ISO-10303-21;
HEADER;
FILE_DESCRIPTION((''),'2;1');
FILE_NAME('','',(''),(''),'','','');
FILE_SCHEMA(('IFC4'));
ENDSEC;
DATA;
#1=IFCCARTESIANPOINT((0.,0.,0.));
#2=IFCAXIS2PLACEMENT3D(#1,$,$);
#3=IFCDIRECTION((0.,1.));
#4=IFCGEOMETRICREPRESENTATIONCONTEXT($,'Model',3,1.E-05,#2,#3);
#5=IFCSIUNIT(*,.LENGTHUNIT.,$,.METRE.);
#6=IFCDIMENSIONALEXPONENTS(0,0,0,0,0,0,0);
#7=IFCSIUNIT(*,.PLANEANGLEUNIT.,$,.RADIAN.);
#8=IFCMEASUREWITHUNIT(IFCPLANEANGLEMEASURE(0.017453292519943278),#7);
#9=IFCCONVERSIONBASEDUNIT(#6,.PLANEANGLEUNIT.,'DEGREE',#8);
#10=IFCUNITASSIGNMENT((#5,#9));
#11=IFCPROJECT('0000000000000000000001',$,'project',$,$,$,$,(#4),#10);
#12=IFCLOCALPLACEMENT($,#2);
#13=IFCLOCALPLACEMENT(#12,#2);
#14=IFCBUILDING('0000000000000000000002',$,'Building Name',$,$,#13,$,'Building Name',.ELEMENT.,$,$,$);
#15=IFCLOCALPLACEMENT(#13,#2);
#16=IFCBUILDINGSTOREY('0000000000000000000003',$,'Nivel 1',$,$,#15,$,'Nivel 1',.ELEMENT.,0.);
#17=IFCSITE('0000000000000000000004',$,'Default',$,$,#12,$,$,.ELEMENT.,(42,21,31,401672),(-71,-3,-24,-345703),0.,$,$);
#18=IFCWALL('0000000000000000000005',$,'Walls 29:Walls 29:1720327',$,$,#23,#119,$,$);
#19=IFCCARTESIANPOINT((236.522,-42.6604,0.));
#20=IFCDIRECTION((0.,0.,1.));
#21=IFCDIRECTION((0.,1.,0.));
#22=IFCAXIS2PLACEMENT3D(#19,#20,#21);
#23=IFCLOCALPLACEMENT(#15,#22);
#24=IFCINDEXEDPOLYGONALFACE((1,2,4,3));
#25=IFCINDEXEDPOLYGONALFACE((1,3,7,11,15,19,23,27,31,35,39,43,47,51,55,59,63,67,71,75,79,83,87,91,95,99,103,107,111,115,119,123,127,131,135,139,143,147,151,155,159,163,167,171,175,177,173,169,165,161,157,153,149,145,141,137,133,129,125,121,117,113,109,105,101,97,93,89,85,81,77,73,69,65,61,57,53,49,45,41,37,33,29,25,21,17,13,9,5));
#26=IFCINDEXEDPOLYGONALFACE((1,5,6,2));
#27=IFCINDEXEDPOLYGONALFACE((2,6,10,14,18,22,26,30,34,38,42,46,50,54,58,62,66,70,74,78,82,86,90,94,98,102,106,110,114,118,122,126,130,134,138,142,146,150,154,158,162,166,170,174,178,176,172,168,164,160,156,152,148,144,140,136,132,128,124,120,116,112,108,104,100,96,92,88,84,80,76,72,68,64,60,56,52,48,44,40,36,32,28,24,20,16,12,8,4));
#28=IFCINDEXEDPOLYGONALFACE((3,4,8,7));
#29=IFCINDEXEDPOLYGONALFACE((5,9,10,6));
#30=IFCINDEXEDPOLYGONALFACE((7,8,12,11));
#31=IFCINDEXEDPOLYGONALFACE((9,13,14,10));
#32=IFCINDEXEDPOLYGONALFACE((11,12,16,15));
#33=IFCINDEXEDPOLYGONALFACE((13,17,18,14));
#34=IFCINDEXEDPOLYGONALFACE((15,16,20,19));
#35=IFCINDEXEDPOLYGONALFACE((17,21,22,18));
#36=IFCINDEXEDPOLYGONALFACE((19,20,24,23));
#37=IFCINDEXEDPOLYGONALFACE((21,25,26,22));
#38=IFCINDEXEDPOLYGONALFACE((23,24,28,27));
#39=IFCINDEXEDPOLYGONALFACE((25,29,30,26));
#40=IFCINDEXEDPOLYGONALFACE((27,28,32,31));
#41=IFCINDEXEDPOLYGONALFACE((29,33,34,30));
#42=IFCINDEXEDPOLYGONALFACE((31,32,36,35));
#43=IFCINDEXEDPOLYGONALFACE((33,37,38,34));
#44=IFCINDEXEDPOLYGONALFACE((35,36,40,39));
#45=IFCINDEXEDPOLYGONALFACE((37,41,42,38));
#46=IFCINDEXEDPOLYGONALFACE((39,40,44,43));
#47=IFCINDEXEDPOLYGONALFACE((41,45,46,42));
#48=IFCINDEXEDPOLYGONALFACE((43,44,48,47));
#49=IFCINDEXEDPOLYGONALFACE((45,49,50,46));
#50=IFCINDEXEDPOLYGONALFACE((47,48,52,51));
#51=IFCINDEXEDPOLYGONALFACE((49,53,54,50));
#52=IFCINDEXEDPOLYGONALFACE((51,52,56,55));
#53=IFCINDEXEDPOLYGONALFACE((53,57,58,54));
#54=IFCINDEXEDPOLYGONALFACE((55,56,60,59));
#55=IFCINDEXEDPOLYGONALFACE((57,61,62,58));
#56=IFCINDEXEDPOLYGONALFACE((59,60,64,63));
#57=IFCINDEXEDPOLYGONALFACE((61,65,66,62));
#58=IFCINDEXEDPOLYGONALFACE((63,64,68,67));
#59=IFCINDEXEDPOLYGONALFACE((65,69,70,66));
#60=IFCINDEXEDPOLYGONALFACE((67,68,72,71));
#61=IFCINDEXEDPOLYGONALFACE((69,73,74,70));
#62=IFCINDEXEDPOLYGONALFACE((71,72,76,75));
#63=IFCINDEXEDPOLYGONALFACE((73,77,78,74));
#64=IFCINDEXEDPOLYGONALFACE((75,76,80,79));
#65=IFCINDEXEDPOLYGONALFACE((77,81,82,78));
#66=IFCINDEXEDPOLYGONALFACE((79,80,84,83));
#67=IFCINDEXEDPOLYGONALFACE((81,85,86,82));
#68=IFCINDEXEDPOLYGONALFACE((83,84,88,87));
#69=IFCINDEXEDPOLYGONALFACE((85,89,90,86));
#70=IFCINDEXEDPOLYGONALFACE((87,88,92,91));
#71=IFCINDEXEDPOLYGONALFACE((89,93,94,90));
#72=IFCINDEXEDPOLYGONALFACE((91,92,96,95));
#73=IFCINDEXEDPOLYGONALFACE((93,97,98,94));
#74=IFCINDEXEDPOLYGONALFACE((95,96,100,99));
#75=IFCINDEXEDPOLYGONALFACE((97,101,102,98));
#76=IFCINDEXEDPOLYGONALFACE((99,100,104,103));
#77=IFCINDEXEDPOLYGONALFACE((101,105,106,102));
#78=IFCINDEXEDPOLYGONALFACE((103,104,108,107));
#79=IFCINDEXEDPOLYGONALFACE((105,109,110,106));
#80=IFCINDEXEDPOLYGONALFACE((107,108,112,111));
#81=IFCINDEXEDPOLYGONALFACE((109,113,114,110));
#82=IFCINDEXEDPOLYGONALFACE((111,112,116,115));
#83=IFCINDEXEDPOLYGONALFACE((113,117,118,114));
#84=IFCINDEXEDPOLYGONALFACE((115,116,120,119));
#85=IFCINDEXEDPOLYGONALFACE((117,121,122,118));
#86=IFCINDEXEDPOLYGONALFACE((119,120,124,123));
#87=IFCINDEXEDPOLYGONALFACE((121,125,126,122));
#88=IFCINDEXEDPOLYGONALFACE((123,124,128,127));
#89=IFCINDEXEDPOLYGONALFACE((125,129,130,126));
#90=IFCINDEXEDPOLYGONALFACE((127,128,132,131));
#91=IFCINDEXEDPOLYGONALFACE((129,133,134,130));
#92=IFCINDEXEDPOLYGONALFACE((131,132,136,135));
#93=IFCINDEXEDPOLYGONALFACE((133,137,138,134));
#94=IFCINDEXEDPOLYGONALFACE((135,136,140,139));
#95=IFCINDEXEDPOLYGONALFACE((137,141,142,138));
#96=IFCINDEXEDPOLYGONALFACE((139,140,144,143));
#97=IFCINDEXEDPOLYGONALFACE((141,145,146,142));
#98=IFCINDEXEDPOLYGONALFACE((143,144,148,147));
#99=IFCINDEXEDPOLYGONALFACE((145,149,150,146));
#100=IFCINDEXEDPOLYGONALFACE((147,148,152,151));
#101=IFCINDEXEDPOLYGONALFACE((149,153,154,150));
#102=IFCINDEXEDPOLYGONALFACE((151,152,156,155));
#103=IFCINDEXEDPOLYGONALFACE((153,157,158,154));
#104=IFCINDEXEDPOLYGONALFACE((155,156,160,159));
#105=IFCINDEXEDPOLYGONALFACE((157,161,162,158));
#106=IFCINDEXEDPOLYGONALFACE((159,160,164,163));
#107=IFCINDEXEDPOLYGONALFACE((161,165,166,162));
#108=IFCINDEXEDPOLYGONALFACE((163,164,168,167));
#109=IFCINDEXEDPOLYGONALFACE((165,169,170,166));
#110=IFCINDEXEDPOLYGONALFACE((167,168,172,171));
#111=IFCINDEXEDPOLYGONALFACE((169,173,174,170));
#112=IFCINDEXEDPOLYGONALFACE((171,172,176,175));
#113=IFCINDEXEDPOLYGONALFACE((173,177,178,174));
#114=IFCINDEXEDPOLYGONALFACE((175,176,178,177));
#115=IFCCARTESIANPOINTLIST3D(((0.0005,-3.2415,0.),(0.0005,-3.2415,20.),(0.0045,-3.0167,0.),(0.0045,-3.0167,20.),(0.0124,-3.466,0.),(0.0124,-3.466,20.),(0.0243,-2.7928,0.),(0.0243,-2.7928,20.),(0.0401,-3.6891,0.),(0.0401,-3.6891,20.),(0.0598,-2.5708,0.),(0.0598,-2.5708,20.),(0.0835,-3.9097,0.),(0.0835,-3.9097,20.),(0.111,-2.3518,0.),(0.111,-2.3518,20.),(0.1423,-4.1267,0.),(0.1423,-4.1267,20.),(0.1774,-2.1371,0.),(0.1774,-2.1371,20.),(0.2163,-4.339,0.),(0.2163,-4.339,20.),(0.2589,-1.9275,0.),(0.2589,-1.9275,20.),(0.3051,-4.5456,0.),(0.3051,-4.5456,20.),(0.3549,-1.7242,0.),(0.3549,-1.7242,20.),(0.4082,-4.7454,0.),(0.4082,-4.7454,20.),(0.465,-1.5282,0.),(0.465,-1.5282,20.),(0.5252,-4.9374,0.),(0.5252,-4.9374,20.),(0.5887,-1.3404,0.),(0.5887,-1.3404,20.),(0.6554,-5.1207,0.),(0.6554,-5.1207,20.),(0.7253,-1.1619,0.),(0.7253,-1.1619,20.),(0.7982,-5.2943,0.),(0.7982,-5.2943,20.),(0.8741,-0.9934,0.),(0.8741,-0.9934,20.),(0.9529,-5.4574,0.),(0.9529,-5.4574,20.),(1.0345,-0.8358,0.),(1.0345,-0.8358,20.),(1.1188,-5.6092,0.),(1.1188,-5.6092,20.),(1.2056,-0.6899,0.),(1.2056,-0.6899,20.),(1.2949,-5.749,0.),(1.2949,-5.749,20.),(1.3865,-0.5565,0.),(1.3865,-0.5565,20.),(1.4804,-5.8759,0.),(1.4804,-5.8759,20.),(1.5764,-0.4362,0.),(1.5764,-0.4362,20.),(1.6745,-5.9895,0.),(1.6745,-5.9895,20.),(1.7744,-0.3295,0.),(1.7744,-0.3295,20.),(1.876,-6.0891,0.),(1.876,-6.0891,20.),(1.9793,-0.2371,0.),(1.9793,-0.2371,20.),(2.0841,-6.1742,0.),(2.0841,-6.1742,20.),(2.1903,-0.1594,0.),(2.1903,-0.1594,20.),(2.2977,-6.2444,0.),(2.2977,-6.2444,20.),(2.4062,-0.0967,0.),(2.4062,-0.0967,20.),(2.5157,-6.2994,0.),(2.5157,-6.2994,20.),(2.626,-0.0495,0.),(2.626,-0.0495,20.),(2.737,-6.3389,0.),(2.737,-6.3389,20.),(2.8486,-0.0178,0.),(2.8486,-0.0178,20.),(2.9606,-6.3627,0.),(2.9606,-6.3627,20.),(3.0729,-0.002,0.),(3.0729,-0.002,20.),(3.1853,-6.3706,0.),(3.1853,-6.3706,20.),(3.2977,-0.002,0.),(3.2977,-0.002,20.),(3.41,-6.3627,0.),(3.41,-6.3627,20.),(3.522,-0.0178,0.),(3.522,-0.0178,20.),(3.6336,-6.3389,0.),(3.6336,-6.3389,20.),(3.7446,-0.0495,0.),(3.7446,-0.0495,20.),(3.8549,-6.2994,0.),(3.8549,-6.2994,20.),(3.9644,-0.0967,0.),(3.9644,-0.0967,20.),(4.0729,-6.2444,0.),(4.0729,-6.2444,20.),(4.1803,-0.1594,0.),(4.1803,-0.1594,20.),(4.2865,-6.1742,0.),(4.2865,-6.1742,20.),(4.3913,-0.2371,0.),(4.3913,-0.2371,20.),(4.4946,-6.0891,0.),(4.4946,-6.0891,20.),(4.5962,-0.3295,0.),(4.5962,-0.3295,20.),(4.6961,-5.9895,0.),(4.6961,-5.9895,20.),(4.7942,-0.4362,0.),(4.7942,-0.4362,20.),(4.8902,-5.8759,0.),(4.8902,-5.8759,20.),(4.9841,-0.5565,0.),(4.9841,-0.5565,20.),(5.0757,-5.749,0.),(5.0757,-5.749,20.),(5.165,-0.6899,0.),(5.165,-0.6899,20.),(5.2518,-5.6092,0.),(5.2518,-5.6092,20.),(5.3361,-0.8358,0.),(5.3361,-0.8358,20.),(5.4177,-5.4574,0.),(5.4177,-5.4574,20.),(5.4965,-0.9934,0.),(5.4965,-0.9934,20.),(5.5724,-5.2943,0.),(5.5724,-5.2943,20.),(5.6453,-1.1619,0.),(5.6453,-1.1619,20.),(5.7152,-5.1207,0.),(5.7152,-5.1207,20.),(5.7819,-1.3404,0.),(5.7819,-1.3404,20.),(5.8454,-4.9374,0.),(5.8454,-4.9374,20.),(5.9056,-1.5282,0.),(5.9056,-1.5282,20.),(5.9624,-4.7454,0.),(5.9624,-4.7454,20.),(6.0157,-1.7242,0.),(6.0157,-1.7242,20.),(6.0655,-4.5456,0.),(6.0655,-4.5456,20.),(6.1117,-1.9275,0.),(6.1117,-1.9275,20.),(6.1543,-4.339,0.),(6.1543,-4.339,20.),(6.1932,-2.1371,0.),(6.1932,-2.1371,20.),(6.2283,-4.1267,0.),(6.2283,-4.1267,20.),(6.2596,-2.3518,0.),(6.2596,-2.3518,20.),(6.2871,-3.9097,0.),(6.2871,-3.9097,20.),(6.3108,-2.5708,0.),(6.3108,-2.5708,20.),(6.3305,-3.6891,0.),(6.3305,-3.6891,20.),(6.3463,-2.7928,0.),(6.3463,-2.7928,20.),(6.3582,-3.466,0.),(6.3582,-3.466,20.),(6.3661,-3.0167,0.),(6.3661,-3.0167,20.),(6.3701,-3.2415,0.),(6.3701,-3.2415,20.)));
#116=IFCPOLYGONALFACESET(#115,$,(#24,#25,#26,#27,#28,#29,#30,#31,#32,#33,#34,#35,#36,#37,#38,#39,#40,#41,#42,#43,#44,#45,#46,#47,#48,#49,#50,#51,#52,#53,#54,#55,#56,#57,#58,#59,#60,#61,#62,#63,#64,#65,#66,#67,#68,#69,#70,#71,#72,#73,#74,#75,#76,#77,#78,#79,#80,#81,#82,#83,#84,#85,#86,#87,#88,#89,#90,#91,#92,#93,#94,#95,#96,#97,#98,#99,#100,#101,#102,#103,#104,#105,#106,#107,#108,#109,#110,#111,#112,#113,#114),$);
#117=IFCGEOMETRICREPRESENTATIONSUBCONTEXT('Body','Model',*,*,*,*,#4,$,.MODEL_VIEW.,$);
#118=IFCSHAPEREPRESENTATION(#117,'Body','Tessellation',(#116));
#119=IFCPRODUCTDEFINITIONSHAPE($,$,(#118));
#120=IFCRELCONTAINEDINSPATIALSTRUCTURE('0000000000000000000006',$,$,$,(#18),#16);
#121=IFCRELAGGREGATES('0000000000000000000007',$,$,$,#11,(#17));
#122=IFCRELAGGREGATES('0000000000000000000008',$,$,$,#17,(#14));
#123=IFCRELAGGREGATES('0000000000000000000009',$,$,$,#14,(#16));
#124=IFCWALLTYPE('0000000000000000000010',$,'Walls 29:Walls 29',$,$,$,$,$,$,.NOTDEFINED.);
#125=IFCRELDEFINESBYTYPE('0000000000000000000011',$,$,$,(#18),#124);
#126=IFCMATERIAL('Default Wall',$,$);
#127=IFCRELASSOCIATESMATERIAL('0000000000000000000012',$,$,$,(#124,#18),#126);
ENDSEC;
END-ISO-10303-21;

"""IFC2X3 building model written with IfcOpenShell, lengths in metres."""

from ifc_helpers import new_model, entity, si_unit, converted_unit, direction, frame, frame_2d, origin, place, context, subcontext, project, spatial, circle, extrude, material, type_object, element, save


model = new_model("IFC2X3")

# Units and contexts
model_context = context("Model", 3, precision=1e-05, world=origin(), true_north=direction((0.0, 1.0)))
body_context = subcontext(model_context, "Body", "Model", "MODEL_VIEW")
ifc_project = project(units=[si_unit("LENGTHUNIT", "METRE"), converted_unit("PLANEANGLEUNIT", "DEGREE", entity("IfcPlaneAngleMeasure", 0.017453292519943278), si_unit("PLANEANGLEUNIT", "RADIAN"), dimensions=[0, 0, 0, 0, 0, 0, 0])], contexts=[model_context])

# Site, building, storey
site_placement = place(None, origin())
site = spatial("IfcSite", under=ifc_project, at=site_placement, Name="Default", CompositionType="ELEMENT", RefLatitude=(42, 21, 31, 401672), RefLongitude=(-71, -3, -24, -345703), RefElevation=0.0)
building_placement = place(site_placement, origin())
building = spatial("IfcBuilding", under=site, at=building_placement, Name="Building Name", LongName="Building Name", CompositionType="ELEMENT")
storey_placement = place(building_placement, origin())
storey = spatial("IfcBuildingStorey", under=building, at=storey_placement, Name="Nivel 1", LongName="Nivel 1", CompositionType="ELEMENT", Elevation=0.0)

# Wall
ifc_material_1 = material(Name="Default Wall")
wall_type_1 = type_object("IfcWallType", Name="Walls 29:Walls 29", PredefinedType="NOTDEFINED", material=ifc_material_1)
wall_1_placement = place(storey_placement, frame((236.522, -42.6604, 0.0), z_axis=(0.0, 0.0, 1.0), x_axis=(0.0, 1.0, 0.0)))
element("IfcWall", 1, at=wall_1_placement, inside=storey, type_object=wall_type_1, material=ifc_material_1, Name="Walls 29:Walls 29:1720327", context=body_context, shape_type="SweptSolid", body=[
    extrude(circle(Radius=3.1853, at=frame_2d((0.0, 0.0), x_axis=(1.0, 0.0))), frame((3.1853, -3.1853, 0.0), z_axis=(0.0, 0.0, 1.0), x_axis=(0.0, -1.0, 0.0)), (0.0, 0.0, 1.0), 20.0),
])

save(model, "model.ifc")
